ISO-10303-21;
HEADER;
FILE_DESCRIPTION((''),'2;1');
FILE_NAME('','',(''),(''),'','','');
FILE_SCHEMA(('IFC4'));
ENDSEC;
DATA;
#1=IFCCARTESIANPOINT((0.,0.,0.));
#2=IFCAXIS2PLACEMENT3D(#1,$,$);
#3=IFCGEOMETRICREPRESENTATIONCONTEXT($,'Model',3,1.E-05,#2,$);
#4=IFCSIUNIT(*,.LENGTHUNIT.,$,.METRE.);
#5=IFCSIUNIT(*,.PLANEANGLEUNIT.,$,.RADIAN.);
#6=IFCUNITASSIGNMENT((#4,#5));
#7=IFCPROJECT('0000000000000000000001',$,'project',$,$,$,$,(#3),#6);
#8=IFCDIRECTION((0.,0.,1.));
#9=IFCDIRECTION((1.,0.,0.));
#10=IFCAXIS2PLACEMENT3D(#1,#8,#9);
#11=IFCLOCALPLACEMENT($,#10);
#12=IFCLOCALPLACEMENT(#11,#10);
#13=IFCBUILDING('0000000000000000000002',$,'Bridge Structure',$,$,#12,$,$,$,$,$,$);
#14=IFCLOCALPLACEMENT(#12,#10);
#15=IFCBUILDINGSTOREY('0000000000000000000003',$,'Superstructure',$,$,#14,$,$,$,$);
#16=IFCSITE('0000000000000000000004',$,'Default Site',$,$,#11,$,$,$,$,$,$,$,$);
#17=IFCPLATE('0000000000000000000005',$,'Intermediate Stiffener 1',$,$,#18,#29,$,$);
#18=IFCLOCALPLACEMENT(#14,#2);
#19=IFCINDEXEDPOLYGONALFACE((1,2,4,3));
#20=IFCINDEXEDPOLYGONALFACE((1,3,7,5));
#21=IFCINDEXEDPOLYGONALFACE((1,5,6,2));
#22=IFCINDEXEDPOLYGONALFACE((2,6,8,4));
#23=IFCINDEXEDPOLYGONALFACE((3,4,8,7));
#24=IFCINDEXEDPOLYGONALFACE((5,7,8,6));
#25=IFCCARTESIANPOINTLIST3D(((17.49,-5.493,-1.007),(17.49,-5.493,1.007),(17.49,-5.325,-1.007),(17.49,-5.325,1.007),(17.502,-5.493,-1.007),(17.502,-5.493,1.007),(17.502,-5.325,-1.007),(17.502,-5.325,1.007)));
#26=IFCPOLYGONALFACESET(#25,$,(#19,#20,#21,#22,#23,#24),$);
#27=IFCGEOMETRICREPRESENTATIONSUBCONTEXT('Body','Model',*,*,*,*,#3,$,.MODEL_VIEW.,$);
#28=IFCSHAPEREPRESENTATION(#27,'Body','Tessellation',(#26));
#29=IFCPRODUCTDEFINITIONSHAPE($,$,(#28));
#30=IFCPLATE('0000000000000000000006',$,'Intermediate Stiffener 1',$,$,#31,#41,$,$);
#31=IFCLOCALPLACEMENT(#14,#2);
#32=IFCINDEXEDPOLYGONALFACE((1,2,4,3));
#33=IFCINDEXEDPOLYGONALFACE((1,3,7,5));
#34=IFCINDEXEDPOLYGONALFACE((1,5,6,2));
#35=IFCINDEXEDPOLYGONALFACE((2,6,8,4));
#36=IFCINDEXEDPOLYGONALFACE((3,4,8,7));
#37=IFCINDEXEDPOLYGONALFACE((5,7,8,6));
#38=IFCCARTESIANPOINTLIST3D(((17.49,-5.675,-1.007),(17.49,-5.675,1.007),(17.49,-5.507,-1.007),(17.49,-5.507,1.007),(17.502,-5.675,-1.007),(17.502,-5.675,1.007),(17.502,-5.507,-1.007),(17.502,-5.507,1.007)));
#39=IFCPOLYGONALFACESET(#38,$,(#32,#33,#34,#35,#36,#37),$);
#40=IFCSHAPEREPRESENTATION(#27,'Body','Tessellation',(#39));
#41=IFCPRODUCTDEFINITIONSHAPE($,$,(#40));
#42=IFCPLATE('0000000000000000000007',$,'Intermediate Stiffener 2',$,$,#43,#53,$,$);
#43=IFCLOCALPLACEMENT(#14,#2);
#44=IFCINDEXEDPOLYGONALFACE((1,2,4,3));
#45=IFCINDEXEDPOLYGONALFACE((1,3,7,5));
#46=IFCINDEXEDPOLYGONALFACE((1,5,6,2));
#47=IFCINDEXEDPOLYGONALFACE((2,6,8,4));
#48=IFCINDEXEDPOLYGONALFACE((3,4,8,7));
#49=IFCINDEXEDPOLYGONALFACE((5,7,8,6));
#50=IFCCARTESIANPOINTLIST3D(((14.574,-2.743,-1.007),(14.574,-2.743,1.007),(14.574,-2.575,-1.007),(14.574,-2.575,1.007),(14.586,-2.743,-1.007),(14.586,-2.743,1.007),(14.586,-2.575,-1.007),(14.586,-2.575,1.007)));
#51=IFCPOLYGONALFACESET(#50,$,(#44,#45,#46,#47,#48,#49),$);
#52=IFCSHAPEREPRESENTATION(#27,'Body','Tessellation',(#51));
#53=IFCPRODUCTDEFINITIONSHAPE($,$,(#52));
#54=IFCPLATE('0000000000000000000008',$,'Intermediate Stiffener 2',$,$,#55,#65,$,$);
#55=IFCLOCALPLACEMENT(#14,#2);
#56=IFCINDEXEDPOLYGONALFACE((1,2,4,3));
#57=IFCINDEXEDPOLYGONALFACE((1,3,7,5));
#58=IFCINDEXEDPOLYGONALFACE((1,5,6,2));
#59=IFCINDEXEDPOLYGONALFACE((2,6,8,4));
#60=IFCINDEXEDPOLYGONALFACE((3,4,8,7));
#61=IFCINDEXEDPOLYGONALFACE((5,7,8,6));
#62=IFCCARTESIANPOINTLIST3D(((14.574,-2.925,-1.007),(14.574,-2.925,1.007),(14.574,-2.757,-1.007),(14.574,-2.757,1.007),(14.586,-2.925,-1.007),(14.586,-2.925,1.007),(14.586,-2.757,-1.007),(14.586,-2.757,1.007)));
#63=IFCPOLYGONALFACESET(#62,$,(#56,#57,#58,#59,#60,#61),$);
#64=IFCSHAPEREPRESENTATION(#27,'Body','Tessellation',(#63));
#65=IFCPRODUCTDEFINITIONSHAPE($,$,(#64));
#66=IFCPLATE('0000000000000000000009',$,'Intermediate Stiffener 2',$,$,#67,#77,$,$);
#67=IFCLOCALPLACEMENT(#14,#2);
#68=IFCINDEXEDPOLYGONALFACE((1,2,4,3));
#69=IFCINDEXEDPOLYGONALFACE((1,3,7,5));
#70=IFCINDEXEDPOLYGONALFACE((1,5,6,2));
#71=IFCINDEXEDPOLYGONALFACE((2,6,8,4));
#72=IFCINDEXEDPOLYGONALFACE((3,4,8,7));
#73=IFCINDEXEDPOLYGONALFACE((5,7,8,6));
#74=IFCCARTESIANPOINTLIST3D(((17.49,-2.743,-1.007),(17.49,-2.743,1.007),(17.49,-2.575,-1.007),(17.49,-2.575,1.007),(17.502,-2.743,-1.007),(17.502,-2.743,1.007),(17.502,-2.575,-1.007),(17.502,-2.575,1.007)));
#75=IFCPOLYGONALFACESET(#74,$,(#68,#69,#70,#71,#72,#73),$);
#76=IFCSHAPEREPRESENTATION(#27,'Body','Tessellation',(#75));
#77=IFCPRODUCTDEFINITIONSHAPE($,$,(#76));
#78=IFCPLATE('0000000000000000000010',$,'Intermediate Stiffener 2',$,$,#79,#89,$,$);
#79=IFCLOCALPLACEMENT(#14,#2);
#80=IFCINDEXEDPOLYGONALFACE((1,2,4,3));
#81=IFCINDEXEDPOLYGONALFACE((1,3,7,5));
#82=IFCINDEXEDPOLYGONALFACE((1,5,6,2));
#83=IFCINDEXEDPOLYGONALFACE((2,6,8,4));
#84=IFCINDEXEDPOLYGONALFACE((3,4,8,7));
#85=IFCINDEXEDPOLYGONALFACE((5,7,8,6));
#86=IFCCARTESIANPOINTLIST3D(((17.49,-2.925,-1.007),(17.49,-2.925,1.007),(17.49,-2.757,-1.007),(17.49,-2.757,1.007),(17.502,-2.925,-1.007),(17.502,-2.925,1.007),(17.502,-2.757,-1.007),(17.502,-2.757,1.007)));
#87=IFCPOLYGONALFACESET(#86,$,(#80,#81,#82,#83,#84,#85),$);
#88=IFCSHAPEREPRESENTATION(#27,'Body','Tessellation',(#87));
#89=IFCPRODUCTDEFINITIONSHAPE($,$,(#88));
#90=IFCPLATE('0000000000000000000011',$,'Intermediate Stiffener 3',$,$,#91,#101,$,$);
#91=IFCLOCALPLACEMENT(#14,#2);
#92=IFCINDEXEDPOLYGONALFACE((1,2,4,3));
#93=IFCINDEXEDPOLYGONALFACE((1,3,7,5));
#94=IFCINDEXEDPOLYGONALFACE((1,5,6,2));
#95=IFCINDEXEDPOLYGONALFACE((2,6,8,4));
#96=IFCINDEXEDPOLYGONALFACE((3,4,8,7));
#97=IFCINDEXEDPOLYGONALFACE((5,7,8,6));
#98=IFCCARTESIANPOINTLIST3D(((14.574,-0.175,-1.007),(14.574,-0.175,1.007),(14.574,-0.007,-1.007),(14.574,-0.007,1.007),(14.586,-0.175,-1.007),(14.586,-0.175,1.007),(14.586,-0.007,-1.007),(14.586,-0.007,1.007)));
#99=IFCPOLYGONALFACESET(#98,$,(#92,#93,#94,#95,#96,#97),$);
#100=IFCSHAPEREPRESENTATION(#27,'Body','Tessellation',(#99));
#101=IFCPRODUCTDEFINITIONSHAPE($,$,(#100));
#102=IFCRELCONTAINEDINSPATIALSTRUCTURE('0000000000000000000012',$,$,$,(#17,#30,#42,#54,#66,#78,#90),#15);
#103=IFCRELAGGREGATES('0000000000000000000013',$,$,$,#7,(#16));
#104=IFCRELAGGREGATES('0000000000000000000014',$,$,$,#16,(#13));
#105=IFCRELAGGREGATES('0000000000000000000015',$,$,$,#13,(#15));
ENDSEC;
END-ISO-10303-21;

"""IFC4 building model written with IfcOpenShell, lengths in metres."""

from ifc_helpers import new_model, si_unit, frame, origin, origin_with_axes, origin_2d_with_axis, place, context, subcontext, project, spatial, rectangle, extrude, element, save


model = new_model("IFC4")

# Units and contexts
model_context = context("Model", 3, precision=1e-05, world=origin())
body_context = subcontext(model_context, "Body", "Model", "MODEL_VIEW")
ifc_project = project(units=[si_unit("LENGTHUNIT", "METRE"), si_unit("PLANEANGLEUNIT", "RADIAN")], contexts=[model_context])

# Site, building, storey
site_placement = place(None, origin_with_axes())
site = spatial("IfcSite", under=ifc_project, at=site_placement, Name="Default Site")
building_placement = place(site_placement, origin_with_axes())
building = spatial("IfcBuilding", under=site, at=building_placement, Name="Bridge Structure")
storey_placement = place(building_placement, origin_with_axes())
storey = spatial("IfcBuildingStorey", under=building, at=storey_placement, Name="Superstructure")

# Plates
for number, where, z_axis, x_axis, name in (
    (1, (17.496, -5.409, -1.007), (0.0, 0.0, 1.0), (1.0, 0.0, 0.0), "Intermediate Stiffener 1"),
    (2, (17.496, -5.591, -1.007), (0.0, 0.0, 1.0), (1.0, 0.0, 0.0), "Intermediate Stiffener 1"),
    (3, (14.58, -2.659, -1.007), (0.0, 0.0, 1.0), (1.0, 0.0, 0.0), "Intermediate Stiffener 2"),
    (4, (14.58, -2.841, -1.007), (0.0, 0.0, 1.0), (1.0, 0.0, 0.0), "Intermediate Stiffener 2"),
    (5, (17.496, -2.659, -1.007), (0.0, 0.0, 1.0), (1.0, 0.0, 0.0), "Intermediate Stiffener 2"),
    (6, (17.496, -2.841, -1.007), (0.0, 0.0, 1.0), (1.0, 0.0, 0.0), "Intermediate Stiffener 2"),
    (7, (14.58, -0.091, -1.007), (0.0, 0.0, 1.0), (1.0, 0.0, 0.0), "Intermediate Stiffener 3"),
):
    element("IfcPlate", number, at=place(storey_placement, frame(where, z_axis=z_axis, x_axis=x_axis)), inside=storey, Name=name, context=body_context, shape_type="SweptSolid", body=[
        extrude(rectangle(XDim=0.012, YDim=0.168, at=origin_2d_with_axis()), origin_with_axes(), (0.0, 0.0, 1.0), 2.014),
    ])

save(model, "model.ifc")
